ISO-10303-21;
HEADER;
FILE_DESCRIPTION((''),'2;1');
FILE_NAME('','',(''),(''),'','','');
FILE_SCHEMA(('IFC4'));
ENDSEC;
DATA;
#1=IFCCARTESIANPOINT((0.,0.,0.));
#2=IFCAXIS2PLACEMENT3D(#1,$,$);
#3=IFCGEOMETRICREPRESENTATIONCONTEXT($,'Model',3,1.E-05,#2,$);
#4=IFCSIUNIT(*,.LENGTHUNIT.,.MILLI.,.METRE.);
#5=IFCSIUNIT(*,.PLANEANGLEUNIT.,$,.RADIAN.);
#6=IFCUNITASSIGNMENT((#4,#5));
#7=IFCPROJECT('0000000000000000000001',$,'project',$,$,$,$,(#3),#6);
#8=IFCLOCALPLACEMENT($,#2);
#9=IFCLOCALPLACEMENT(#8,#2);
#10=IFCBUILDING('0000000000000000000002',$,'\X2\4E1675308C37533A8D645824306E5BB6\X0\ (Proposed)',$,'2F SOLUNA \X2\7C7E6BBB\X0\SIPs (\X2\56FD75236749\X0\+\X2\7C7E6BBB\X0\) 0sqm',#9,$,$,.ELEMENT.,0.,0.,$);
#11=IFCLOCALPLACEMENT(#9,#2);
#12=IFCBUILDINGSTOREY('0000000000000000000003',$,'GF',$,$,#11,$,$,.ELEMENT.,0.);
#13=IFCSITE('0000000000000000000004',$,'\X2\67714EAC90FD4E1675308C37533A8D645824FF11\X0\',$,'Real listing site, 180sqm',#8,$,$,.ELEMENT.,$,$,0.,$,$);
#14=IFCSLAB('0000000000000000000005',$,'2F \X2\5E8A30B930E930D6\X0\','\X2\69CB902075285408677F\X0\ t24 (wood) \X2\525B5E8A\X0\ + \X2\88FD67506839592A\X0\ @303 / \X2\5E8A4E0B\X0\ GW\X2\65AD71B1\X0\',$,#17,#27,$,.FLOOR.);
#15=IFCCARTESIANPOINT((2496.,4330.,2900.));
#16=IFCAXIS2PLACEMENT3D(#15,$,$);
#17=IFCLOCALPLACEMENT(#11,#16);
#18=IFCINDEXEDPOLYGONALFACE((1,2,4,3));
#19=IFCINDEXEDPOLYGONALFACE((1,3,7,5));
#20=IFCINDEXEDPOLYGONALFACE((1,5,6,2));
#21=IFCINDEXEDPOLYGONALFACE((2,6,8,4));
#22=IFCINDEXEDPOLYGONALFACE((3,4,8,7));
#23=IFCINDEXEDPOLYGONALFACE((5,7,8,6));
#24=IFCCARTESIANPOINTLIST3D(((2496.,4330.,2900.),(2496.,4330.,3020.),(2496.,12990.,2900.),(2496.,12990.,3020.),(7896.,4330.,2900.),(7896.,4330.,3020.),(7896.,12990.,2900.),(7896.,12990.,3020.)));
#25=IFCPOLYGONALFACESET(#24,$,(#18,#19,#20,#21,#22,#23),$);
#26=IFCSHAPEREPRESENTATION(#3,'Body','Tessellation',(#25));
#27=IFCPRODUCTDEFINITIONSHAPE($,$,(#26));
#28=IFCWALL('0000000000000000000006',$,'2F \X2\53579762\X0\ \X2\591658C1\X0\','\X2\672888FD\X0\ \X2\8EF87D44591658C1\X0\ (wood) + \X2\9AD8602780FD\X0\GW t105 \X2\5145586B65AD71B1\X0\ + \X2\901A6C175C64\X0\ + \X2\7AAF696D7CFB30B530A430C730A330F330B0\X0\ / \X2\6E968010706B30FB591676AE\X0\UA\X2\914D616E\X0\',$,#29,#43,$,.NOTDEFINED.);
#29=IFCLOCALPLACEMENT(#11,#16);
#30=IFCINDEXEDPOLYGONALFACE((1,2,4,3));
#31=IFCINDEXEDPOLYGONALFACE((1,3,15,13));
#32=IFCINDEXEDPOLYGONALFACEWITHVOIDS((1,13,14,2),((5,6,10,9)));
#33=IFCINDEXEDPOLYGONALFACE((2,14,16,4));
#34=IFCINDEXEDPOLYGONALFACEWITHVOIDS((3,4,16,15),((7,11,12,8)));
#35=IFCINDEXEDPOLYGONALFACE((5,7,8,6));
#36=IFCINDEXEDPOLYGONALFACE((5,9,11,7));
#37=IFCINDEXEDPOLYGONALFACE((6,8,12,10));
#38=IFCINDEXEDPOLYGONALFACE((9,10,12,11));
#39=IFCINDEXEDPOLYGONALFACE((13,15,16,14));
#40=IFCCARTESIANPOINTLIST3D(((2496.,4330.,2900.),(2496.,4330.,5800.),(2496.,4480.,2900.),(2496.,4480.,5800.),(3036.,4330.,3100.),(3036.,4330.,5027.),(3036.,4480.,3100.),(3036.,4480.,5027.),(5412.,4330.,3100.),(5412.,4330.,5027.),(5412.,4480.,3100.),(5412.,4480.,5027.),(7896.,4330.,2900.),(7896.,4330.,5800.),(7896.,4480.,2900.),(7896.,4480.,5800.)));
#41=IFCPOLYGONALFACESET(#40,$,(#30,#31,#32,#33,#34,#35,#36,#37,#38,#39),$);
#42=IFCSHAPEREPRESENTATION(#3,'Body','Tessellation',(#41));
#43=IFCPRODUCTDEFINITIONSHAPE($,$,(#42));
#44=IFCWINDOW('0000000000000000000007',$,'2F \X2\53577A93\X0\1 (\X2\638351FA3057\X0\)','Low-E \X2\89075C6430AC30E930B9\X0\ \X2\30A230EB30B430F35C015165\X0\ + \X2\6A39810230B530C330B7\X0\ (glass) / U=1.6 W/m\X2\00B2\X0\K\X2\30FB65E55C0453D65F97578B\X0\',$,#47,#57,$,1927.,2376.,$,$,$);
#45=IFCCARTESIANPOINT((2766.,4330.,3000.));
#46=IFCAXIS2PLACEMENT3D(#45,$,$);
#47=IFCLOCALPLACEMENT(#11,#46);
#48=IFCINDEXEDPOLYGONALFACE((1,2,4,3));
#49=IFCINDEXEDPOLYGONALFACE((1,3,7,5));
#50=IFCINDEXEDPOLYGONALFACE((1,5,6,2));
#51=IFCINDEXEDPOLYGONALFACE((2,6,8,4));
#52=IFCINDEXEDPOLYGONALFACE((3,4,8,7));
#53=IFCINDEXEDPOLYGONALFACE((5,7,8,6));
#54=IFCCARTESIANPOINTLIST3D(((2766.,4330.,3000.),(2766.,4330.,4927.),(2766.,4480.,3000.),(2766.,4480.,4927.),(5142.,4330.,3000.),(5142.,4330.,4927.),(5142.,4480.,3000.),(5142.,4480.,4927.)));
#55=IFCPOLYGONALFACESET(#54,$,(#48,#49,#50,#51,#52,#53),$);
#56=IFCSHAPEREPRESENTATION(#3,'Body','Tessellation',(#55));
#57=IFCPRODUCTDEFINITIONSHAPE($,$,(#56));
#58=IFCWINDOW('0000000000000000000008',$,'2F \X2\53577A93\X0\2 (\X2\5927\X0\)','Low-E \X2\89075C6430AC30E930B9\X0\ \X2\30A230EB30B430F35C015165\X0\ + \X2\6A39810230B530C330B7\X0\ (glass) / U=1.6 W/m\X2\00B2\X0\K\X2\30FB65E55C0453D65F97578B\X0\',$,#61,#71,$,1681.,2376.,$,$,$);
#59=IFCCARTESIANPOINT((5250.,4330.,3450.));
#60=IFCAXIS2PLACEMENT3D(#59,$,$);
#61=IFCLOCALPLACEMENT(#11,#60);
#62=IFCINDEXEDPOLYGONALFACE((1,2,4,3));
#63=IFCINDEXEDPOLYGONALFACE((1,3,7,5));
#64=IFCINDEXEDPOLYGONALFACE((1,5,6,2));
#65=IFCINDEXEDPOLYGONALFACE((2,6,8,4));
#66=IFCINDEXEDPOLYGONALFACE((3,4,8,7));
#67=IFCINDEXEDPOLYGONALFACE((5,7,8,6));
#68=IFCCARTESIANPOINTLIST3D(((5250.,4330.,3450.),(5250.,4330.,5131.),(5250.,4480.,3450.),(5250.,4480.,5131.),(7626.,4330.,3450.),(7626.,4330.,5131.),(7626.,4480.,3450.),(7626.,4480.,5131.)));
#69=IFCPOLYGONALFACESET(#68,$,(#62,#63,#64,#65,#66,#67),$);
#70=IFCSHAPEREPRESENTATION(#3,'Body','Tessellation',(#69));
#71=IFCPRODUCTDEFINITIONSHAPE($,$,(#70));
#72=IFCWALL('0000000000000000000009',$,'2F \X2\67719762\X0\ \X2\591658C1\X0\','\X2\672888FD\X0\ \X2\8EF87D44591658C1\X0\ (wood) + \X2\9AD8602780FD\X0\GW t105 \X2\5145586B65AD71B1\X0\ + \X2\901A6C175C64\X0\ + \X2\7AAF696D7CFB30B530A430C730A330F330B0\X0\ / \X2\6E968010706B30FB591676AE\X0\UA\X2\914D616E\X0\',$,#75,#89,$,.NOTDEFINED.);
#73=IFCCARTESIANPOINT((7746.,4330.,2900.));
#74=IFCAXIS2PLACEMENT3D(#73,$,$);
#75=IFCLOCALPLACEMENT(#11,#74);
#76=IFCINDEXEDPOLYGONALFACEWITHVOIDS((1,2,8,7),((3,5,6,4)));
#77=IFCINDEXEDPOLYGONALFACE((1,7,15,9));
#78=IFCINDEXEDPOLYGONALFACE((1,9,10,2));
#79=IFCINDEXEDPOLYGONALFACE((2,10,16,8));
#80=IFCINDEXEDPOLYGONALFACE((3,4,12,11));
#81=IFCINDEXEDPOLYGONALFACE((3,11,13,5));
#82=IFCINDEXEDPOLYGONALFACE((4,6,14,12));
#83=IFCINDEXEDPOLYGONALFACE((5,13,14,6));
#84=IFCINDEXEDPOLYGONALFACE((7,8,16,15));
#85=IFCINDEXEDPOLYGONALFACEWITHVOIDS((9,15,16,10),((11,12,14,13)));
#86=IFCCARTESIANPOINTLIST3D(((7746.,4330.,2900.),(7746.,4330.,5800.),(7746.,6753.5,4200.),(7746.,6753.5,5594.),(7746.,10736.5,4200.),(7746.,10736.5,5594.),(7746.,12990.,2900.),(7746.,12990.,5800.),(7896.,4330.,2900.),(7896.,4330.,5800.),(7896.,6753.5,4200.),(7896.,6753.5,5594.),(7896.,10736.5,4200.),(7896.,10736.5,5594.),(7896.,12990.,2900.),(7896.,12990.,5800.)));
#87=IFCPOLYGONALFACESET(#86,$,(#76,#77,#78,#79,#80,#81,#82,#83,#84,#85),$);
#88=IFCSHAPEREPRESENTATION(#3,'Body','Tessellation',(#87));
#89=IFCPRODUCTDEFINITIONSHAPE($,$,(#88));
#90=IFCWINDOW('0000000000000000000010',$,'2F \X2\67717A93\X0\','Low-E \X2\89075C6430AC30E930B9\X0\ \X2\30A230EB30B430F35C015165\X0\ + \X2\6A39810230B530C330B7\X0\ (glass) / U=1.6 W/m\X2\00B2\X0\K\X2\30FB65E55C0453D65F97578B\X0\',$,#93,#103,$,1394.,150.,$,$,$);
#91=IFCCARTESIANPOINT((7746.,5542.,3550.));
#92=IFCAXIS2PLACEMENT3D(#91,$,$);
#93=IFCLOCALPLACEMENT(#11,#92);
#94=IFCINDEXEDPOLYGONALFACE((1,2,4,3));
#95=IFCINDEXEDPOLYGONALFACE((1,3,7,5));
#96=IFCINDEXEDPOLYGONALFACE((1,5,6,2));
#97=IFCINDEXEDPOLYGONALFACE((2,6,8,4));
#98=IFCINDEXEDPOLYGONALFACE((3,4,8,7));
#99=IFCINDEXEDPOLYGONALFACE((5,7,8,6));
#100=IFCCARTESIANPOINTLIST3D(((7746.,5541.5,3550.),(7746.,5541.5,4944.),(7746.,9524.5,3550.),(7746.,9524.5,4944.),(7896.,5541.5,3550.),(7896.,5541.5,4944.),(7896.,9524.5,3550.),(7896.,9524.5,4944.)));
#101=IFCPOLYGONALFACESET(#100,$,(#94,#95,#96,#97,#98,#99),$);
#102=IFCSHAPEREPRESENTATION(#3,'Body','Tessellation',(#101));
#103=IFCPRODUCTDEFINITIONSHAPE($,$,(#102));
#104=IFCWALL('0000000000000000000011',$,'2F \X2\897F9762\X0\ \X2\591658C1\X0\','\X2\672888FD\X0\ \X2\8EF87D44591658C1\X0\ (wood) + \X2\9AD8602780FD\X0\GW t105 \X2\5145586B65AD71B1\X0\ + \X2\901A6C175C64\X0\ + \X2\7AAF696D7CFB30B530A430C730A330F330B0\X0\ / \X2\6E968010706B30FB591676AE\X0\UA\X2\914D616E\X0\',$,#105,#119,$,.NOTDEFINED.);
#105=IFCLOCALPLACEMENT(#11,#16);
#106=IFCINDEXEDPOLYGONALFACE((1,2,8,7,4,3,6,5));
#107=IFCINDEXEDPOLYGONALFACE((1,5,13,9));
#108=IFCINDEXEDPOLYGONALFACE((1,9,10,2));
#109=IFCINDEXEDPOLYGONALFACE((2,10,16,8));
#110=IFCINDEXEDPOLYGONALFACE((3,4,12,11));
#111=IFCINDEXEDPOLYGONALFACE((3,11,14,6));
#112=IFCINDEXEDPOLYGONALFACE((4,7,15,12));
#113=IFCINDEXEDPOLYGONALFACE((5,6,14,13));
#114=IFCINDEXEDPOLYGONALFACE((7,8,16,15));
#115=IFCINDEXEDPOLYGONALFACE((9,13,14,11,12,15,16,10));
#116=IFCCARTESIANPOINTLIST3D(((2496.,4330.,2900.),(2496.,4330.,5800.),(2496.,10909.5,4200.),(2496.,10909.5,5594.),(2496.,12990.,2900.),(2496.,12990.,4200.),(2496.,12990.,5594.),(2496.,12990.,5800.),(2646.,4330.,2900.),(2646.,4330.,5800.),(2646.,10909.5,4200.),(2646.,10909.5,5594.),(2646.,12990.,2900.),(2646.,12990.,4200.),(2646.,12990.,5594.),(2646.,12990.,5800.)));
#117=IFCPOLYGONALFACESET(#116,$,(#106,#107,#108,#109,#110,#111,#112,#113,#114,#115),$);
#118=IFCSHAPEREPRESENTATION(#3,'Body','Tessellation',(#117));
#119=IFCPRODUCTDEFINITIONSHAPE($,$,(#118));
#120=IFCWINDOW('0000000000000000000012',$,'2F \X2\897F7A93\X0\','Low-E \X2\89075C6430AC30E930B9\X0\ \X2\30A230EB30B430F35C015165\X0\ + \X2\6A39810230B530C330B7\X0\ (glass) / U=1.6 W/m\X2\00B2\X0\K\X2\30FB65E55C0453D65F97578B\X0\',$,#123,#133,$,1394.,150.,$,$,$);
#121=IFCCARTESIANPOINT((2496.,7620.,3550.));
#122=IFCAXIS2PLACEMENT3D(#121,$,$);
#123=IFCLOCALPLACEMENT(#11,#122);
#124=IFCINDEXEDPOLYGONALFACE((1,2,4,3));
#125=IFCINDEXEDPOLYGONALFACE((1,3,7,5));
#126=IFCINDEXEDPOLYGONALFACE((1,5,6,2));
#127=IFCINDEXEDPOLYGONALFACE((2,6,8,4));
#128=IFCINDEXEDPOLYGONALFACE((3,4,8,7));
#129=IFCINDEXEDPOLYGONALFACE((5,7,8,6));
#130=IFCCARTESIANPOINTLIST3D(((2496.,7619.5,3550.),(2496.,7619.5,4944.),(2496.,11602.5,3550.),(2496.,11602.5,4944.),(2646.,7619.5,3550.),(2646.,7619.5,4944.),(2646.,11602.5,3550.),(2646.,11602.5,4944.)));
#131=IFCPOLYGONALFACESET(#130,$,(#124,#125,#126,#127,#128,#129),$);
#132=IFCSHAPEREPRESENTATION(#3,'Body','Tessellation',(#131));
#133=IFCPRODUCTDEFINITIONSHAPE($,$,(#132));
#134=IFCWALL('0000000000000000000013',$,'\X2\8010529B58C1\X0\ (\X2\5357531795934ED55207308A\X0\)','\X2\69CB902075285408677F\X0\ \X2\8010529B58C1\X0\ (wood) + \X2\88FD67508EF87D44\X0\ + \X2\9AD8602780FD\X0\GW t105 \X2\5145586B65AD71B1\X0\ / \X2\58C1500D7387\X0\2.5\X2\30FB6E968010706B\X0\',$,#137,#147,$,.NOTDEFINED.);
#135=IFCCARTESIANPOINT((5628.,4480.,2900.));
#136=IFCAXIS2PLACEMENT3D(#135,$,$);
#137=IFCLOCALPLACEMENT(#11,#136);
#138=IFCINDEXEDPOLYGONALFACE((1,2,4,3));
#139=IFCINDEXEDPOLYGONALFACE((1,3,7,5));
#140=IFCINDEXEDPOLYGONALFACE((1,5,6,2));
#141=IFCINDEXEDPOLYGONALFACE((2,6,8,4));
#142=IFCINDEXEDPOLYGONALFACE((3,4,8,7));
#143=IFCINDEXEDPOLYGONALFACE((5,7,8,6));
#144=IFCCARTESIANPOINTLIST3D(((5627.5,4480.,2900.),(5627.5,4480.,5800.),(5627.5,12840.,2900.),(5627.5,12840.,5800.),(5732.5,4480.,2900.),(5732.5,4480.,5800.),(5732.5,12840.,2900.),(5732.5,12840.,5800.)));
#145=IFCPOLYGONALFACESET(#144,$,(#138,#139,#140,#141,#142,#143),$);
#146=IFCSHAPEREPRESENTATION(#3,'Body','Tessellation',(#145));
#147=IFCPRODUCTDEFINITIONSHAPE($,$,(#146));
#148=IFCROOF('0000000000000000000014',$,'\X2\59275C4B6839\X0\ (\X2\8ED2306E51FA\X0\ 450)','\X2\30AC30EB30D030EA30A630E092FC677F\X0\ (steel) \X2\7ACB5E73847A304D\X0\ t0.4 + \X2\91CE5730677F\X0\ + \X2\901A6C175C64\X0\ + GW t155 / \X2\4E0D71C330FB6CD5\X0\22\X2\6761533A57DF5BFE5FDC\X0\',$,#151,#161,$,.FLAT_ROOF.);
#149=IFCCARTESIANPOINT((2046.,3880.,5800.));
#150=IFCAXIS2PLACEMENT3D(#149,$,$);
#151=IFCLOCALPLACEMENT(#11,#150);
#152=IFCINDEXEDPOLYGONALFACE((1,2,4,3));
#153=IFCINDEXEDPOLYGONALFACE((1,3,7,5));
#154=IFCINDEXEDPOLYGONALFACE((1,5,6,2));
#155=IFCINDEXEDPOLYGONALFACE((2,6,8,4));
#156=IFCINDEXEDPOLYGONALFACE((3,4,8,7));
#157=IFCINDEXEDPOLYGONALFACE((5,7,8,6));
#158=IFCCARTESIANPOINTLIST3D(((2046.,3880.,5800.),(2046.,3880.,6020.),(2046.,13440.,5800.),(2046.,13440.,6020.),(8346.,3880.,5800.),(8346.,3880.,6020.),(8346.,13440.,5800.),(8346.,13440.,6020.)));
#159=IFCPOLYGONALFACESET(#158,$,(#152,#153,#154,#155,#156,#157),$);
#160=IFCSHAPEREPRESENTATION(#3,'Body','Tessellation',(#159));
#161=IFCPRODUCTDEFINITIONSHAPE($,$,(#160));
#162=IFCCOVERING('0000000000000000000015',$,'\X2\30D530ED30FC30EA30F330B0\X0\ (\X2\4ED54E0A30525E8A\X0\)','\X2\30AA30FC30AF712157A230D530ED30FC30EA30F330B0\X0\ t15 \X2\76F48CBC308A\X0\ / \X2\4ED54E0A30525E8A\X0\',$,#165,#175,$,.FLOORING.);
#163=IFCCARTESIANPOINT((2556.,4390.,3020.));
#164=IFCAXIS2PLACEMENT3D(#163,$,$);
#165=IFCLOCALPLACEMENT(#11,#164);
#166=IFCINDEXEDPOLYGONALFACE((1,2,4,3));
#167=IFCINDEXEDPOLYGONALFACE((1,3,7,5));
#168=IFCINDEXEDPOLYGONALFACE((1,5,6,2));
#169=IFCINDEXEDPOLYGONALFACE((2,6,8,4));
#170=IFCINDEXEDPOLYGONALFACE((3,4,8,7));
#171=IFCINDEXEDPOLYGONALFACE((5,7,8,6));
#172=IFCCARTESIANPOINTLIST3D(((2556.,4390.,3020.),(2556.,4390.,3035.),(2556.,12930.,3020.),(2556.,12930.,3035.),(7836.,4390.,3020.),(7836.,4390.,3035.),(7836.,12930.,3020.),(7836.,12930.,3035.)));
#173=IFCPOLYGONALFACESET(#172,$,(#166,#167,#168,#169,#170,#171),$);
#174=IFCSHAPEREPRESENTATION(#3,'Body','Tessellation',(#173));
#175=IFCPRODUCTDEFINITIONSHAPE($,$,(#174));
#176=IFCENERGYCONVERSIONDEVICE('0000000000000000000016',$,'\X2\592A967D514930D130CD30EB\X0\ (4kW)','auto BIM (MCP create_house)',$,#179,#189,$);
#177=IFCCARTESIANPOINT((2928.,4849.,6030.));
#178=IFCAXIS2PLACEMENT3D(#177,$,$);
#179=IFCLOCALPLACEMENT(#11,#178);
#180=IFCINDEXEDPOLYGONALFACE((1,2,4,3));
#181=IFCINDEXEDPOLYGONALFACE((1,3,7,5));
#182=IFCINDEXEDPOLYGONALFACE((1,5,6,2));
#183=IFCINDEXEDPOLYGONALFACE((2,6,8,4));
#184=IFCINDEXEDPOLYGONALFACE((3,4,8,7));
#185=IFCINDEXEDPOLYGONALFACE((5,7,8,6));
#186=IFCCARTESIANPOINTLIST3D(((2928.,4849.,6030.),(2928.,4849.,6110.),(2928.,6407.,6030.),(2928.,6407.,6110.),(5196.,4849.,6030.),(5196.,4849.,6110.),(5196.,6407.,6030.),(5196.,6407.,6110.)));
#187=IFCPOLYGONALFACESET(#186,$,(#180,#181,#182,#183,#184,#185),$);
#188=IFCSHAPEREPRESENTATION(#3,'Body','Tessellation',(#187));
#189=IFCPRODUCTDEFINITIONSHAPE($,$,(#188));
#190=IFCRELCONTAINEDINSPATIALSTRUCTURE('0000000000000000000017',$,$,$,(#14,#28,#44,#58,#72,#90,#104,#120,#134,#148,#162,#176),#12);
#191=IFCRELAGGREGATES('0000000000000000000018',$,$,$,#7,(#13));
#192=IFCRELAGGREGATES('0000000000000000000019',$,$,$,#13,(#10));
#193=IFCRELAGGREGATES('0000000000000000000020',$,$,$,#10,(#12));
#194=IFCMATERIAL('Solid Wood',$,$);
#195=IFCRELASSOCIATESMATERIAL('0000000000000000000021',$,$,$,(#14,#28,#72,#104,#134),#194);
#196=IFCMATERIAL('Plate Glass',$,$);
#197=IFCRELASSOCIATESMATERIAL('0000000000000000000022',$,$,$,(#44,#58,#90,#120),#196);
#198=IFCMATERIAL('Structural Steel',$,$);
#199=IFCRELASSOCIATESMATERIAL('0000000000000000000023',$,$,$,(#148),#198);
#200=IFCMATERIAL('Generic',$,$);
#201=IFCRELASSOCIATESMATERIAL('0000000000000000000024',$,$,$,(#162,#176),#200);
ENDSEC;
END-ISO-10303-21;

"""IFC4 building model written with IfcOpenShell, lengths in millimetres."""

from ifc_helpers import new_model, si_unit, frame, frame_2d, origin, place, context, project, spatial, rectangle, extrude, material, element, fill, save


model = new_model("IFC4")

# Units and contexts
model_context = context("Model", 3, precision=1e-05, world=origin())
ifc_project = project(units=[si_unit("LENGTHUNIT", "METRE", prefix="MILLI"), si_unit("PLANEANGLEUNIT", "RADIAN")], contexts=[model_context])

# Site, building, storey
site_placement = place(None, origin())
site = spatial("IfcSite", under=ifc_project, at=site_placement, Name="東京都世田谷区赤堤１", ObjectType="Real listing site, 180sqm", CompositionType="ELEMENT", RefElevation=0.0)
building_placement = place(site_placement, origin())
building = spatial("IfcBuilding", under=site, at=building_placement, Name="世田谷区赤堤の家 (Proposed)", ObjectType="2F SOLUNA 籾殻SIPs (国産杉+籾殻) 0sqm", CompositionType="ELEMENT", ElevationOfRefHeight=0.0, ElevationOfTerrain=0.0)
storey_placement = place(building_placement, origin())
storey = spatial("IfcBuildingStorey", under=building, at=storey_placement, Name="GF", CompositionType="ELEMENT", Elevation=0.0)

# Slab
ifc_material_1 = material(Name="Solid Wood")
slab_placement = place(storey_placement, frame((2496.0, 4330.0, 2900.0)))
element("IfcSlab", 1, at=slab_placement, inside=storey, material=ifc_material_1, Name="2F 床スラブ", Description="構造用合板 t24 (wood) 剛床 + 製材根太 @303 / 床下 GW断熱", PredefinedType="FLOOR", context=model_context, shape_type="SweptSolid", body=[
    extrude(rectangle(XDim=5400.0, YDim=8660.0, at=frame_2d((2700.0, 4330.0))), frame((2496.0, 4330.0, 2900.0)), (0.0, 0.0, 1.0), 120.0),
])

# Wall, openings, windows
wall_1_placement = place(storey_placement, frame((2496.0, 4330.0, 2900.0)))
wall_1 = element("IfcWall", 2, at=wall_1_placement, inside=storey, material=ifc_material_1, Name="2F 南面 外壁", Description="木製 軸組外壁 (wood) + 高性能GW t105 充填断熱 + 通気層 + 窯業系サイディング / 準耐火・外皮UA配慮", PredefinedType="NOTDEFINED", context=model_context, shape_type="SweptSolid", body=[
    extrude(rectangle(XDim=5400.0, YDim=150.0, at=frame_2d((2700.0, 75.0))), frame((2496.0, 4330.0, 2900.0)), (0.0, 0.0, 1.0), 2900.0),
])
opening_1_placement = place(storey_placement, frame((2766.0, 4330.0, 3000.0)))
opening_1 = element("IfcOpeningElement", 3, at=opening_1_placement, cuts=wall_1, PredefinedType="NOTDEFINED", context=model_context, shape_type="SweptSolid", body=[
    extrude(rectangle(XDim=2376.0, YDim=150.0, at=frame_2d((1188.0, 75.0))), frame((2766.0, 4330.0, 3000.0)), (0.0, 0.0, 1.0), 1927.0),
])
opening_2_placement = place(storey_placement, frame((5250.0, 4330.0, 3450.0)))
opening_2 = element("IfcOpeningElement", 4, at=opening_2_placement, cuts=wall_1, PredefinedType="NOTDEFINED", context=model_context, shape_type="SweptSolid", body=[
    extrude(rectangle(XDim=2376.0, YDim=150.0, at=frame_2d((1188.0, 75.0))), frame((5250.0, 4330.0, 3450.0)), (0.0, 0.0, 1.0), 1681.0),
])
ifc_material_2 = material(Name="Plate Glass")
window_1_placement = place(storey_placement, frame((2766.0, 4330.0, 3000.0)))
window_1 = element("IfcWindow", 5, at=window_1_placement, inside=storey, material=ifc_material_2, Name="2F 南窓1 (掃出し)", Description="Low-E 複層ガラス アルゴン封入 + 樹脂サッシ (glass) / U=1.6 W/m²K・日射取得型", OverallHeight=1927.0, OverallWidth=2376.0, context=model_context, shape_type="SweptSolid", body=[
    extrude(rectangle(XDim=2376.0, YDim=150.0, at=frame_2d((1188.0, 75.0))), frame((2766.0, 4330.0, 3000.0)), (0.0, 0.0, 1.0), 1927.0),
])
fill(opening_1, window_1)
window_2_placement = place(storey_placement, frame((5250.0, 4330.0, 3450.0)))
window_2 = element("IfcWindow", 6, at=window_2_placement, inside=storey, material=ifc_material_2, Name="2F 南窓2 (大)", Description="Low-E 複層ガラス アルゴン封入 + 樹脂サッシ (glass) / U=1.6 W/m²K・日射取得型", OverallHeight=1681.0, OverallWidth=2376.0, context=model_context, shape_type="SweptSolid", body=[
    extrude(rectangle(XDim=2376.0, YDim=150.0, at=frame_2d((1188.0, 75.0))), frame((5250.0, 4330.0, 3450.0)), (0.0, 0.0, 1.0), 1681.0),
])
fill(opening_2, window_2)

# Walls, openings, windows
wall_2_placement = place(storey_placement, frame((7746.0, 4330.0, 2900.0)))
wall_2 = element("IfcWall", 7, at=wall_2_placement, inside=storey, material=ifc_material_1, Name="2F 東面 外壁", Description="木製 軸組外壁 (wood) + 高性能GW t105 充填断熱 + 通気層 + 窯業系サイディング / 準耐火・外皮UA配慮", PredefinedType="NOTDEFINED", context=model_context, shape_type="SweptSolid", body=[
    extrude(rectangle(XDim=150.0, YDim=8660.0, at=frame_2d((75.0, 4330.0))), frame((7746.0, 4330.0, 2900.0)), (0.0, 0.0, 1.0), 2900.0),
])
opening_3_placement = place(storey_placement, frame((7746.0, 5542.0, 3550.0)))
opening_3 = element("IfcOpeningElement", 8, at=opening_3_placement, cuts=wall_2, PredefinedType="NOTDEFINED", context=model_context, shape_type="SweptSolid", body=[
    extrude(rectangle(XDim=150.0, YDim=3983.0, at=frame_2d((75.0, 1991.0))), frame((7746.0, 5542.0, 3550.0)), (0.0, 0.0, 1.0), 1394.0),
])
window_3_placement = place(storey_placement, frame((7746.0, 5542.0, 3550.0)))
window_3 = element("IfcWindow", 9, at=window_3_placement, inside=storey, material=ifc_material_2, Name="2F 東窓", Description="Low-E 複層ガラス アルゴン封入 + 樹脂サッシ (glass) / U=1.6 W/m²K・日射取得型", OverallHeight=1394.0, OverallWidth=150.0, context=model_context, shape_type="SweptSolid", body=[
    extrude(rectangle(XDim=150.0, YDim=3983.0, at=frame_2d((75.0, 1991.0))), frame((7746.0, 5542.0, 3550.0)), (0.0, 0.0, 1.0), 1394.0),
])
fill(opening_3, window_3)
wall_3_placement = place(storey_placement, frame((2496.0, 4330.0, 2900.0)))
wall_3 = element("IfcWall", 10, at=wall_3_placement, inside=storey, material=ifc_material_1, Name="2F 西面 外壁", Description="木製 軸組外壁 (wood) + 高性能GW t105 充填断熱 + 通気層 + 窯業系サイディング / 準耐火・外皮UA配慮", PredefinedType="NOTDEFINED", context=model_context, shape_type="SweptSolid", body=[
    extrude(rectangle(XDim=150.0, YDim=8660.0, at=frame_2d((75.0, 4330.0))), frame((2496.0, 4330.0, 2900.0)), (0.0, 0.0, 1.0), 2900.0),
])
opening_4_placement = place(storey_placement, frame((2496.0, 7620.0, 3550.0)))
opening_4 = element("IfcOpeningElement", 11, at=opening_4_placement, cuts=wall_3, PredefinedType="NOTDEFINED", context=model_context, shape_type="SweptSolid", body=[
    extrude(rectangle(XDim=150.0, YDim=3983.0, at=frame_2d((75.0, 1991.0))), frame((2496.0, 7620.0, 3550.0)), (0.0, 0.0, 1.0), 1394.0),
])
window_4_placement = place(storey_placement, frame((2496.0, 7620.0, 3550.0)))
window_4 = element("IfcWindow", 12, at=window_4_placement, inside=storey, material=ifc_material_2, Name="2F 西窓", Description="Low-E 複層ガラス アルゴン封入 + 樹脂サッシ (glass) / U=1.6 W/m²K・日射取得型", OverallHeight=1394.0, OverallWidth=150.0, context=model_context, shape_type="SweptSolid", body=[
    extrude(rectangle(XDim=150.0, YDim=3983.0, at=frame_2d((75.0, 1991.0))), frame((2496.0, 7620.0, 3550.0)), (0.0, 0.0, 1.0), 1394.0),
])
fill(opening_4, window_4)

# Wall
wall_4_placement = place(storey_placement, frame((5628.0, 4480.0, 2900.0)))
element("IfcWall", 13, at=wall_4_placement, inside=storey, material=ifc_material_1, Name="耐力壁 (南北間仕切り)", Description="構造用合板 耐力壁 (wood) + 製材軸組 + 高性能GW t105 充填断熱 / 壁倍率2.5・準耐火", PredefinedType="NOTDEFINED", context=model_context, shape_type="SweptSolid", body=[
    extrude(rectangle(XDim=105.0, YDim=8360.0, at=frame_2d((52.0, 4180.0))), frame((5628.0, 4480.0, 2900.0)), (0.0, 0.0, 1.0), 2900.0),
])

# Roof
ifc_material_3 = material(Name="Structural Steel")
roof_placement = place(storey_placement, frame((2046.0, 3880.0, 5800.0)))
element("IfcRoof", 14, at=roof_placement, inside=storey, material=ifc_material_3, Name="大屋根 (軒の出 450)", Description="ガルバリウム鋼板 (steel) 立平葺き t0.4 + 野地板 + 通気層 + GW t155 / 不燃・法22条区域対応", PredefinedType="FLAT_ROOF", context=model_context, shape_type="SweptSolid", body=[
    extrude(rectangle(XDim=6300.0, YDim=9560.0, at=frame_2d((3150.0, 4780.0))), frame((2046.0, 3880.0, 5800.0)), (0.0, 0.0, 1.0), 220.0),
])

# Covering
ifc_material_4 = material(Name="Generic")
covering_placement = place(storey_placement, frame((2556.0, 4390.0, 3020.0)))
element("IfcCovering", 15, at=covering_placement, inside=storey, material=ifc_material_4, Name="フローリング (仕上げ床)", Description="オーク無垢フローリング t15 直貼り / 仕上げ床", PredefinedType="FLOORING", context=model_context, shape_type="SweptSolid", body=[
    extrude(rectangle(XDim=5280.0, YDim=8540.0, at=frame_2d((2640.0, 4270.0))), frame((2556.0, 4390.0, 3020.0)), (0.0, 0.0, 1.0), 15.0),
])

# Energy conversion device
energy_conversion_device_placement = place(storey_placement, frame((2928.0, 4849.0, 6030.0)))
element("IfcEnergyConversionDevice", 16, at=energy_conversion_device_placement, inside=storey, material=ifc_material_4, Name="太陽光パネル (4kW)", Description="auto BIM (MCP create_house)", context=model_context, shape_type="SweptSolid", body=[
    extrude(rectangle(XDim=2268.0, YDim=1558.0, at=frame_2d((1134.0, 779.0))), frame((2928.0, 4849.0, 6030.0)), (0.0, 0.0, 1.0), 80.0),
])

save(model, "model.ifc")
